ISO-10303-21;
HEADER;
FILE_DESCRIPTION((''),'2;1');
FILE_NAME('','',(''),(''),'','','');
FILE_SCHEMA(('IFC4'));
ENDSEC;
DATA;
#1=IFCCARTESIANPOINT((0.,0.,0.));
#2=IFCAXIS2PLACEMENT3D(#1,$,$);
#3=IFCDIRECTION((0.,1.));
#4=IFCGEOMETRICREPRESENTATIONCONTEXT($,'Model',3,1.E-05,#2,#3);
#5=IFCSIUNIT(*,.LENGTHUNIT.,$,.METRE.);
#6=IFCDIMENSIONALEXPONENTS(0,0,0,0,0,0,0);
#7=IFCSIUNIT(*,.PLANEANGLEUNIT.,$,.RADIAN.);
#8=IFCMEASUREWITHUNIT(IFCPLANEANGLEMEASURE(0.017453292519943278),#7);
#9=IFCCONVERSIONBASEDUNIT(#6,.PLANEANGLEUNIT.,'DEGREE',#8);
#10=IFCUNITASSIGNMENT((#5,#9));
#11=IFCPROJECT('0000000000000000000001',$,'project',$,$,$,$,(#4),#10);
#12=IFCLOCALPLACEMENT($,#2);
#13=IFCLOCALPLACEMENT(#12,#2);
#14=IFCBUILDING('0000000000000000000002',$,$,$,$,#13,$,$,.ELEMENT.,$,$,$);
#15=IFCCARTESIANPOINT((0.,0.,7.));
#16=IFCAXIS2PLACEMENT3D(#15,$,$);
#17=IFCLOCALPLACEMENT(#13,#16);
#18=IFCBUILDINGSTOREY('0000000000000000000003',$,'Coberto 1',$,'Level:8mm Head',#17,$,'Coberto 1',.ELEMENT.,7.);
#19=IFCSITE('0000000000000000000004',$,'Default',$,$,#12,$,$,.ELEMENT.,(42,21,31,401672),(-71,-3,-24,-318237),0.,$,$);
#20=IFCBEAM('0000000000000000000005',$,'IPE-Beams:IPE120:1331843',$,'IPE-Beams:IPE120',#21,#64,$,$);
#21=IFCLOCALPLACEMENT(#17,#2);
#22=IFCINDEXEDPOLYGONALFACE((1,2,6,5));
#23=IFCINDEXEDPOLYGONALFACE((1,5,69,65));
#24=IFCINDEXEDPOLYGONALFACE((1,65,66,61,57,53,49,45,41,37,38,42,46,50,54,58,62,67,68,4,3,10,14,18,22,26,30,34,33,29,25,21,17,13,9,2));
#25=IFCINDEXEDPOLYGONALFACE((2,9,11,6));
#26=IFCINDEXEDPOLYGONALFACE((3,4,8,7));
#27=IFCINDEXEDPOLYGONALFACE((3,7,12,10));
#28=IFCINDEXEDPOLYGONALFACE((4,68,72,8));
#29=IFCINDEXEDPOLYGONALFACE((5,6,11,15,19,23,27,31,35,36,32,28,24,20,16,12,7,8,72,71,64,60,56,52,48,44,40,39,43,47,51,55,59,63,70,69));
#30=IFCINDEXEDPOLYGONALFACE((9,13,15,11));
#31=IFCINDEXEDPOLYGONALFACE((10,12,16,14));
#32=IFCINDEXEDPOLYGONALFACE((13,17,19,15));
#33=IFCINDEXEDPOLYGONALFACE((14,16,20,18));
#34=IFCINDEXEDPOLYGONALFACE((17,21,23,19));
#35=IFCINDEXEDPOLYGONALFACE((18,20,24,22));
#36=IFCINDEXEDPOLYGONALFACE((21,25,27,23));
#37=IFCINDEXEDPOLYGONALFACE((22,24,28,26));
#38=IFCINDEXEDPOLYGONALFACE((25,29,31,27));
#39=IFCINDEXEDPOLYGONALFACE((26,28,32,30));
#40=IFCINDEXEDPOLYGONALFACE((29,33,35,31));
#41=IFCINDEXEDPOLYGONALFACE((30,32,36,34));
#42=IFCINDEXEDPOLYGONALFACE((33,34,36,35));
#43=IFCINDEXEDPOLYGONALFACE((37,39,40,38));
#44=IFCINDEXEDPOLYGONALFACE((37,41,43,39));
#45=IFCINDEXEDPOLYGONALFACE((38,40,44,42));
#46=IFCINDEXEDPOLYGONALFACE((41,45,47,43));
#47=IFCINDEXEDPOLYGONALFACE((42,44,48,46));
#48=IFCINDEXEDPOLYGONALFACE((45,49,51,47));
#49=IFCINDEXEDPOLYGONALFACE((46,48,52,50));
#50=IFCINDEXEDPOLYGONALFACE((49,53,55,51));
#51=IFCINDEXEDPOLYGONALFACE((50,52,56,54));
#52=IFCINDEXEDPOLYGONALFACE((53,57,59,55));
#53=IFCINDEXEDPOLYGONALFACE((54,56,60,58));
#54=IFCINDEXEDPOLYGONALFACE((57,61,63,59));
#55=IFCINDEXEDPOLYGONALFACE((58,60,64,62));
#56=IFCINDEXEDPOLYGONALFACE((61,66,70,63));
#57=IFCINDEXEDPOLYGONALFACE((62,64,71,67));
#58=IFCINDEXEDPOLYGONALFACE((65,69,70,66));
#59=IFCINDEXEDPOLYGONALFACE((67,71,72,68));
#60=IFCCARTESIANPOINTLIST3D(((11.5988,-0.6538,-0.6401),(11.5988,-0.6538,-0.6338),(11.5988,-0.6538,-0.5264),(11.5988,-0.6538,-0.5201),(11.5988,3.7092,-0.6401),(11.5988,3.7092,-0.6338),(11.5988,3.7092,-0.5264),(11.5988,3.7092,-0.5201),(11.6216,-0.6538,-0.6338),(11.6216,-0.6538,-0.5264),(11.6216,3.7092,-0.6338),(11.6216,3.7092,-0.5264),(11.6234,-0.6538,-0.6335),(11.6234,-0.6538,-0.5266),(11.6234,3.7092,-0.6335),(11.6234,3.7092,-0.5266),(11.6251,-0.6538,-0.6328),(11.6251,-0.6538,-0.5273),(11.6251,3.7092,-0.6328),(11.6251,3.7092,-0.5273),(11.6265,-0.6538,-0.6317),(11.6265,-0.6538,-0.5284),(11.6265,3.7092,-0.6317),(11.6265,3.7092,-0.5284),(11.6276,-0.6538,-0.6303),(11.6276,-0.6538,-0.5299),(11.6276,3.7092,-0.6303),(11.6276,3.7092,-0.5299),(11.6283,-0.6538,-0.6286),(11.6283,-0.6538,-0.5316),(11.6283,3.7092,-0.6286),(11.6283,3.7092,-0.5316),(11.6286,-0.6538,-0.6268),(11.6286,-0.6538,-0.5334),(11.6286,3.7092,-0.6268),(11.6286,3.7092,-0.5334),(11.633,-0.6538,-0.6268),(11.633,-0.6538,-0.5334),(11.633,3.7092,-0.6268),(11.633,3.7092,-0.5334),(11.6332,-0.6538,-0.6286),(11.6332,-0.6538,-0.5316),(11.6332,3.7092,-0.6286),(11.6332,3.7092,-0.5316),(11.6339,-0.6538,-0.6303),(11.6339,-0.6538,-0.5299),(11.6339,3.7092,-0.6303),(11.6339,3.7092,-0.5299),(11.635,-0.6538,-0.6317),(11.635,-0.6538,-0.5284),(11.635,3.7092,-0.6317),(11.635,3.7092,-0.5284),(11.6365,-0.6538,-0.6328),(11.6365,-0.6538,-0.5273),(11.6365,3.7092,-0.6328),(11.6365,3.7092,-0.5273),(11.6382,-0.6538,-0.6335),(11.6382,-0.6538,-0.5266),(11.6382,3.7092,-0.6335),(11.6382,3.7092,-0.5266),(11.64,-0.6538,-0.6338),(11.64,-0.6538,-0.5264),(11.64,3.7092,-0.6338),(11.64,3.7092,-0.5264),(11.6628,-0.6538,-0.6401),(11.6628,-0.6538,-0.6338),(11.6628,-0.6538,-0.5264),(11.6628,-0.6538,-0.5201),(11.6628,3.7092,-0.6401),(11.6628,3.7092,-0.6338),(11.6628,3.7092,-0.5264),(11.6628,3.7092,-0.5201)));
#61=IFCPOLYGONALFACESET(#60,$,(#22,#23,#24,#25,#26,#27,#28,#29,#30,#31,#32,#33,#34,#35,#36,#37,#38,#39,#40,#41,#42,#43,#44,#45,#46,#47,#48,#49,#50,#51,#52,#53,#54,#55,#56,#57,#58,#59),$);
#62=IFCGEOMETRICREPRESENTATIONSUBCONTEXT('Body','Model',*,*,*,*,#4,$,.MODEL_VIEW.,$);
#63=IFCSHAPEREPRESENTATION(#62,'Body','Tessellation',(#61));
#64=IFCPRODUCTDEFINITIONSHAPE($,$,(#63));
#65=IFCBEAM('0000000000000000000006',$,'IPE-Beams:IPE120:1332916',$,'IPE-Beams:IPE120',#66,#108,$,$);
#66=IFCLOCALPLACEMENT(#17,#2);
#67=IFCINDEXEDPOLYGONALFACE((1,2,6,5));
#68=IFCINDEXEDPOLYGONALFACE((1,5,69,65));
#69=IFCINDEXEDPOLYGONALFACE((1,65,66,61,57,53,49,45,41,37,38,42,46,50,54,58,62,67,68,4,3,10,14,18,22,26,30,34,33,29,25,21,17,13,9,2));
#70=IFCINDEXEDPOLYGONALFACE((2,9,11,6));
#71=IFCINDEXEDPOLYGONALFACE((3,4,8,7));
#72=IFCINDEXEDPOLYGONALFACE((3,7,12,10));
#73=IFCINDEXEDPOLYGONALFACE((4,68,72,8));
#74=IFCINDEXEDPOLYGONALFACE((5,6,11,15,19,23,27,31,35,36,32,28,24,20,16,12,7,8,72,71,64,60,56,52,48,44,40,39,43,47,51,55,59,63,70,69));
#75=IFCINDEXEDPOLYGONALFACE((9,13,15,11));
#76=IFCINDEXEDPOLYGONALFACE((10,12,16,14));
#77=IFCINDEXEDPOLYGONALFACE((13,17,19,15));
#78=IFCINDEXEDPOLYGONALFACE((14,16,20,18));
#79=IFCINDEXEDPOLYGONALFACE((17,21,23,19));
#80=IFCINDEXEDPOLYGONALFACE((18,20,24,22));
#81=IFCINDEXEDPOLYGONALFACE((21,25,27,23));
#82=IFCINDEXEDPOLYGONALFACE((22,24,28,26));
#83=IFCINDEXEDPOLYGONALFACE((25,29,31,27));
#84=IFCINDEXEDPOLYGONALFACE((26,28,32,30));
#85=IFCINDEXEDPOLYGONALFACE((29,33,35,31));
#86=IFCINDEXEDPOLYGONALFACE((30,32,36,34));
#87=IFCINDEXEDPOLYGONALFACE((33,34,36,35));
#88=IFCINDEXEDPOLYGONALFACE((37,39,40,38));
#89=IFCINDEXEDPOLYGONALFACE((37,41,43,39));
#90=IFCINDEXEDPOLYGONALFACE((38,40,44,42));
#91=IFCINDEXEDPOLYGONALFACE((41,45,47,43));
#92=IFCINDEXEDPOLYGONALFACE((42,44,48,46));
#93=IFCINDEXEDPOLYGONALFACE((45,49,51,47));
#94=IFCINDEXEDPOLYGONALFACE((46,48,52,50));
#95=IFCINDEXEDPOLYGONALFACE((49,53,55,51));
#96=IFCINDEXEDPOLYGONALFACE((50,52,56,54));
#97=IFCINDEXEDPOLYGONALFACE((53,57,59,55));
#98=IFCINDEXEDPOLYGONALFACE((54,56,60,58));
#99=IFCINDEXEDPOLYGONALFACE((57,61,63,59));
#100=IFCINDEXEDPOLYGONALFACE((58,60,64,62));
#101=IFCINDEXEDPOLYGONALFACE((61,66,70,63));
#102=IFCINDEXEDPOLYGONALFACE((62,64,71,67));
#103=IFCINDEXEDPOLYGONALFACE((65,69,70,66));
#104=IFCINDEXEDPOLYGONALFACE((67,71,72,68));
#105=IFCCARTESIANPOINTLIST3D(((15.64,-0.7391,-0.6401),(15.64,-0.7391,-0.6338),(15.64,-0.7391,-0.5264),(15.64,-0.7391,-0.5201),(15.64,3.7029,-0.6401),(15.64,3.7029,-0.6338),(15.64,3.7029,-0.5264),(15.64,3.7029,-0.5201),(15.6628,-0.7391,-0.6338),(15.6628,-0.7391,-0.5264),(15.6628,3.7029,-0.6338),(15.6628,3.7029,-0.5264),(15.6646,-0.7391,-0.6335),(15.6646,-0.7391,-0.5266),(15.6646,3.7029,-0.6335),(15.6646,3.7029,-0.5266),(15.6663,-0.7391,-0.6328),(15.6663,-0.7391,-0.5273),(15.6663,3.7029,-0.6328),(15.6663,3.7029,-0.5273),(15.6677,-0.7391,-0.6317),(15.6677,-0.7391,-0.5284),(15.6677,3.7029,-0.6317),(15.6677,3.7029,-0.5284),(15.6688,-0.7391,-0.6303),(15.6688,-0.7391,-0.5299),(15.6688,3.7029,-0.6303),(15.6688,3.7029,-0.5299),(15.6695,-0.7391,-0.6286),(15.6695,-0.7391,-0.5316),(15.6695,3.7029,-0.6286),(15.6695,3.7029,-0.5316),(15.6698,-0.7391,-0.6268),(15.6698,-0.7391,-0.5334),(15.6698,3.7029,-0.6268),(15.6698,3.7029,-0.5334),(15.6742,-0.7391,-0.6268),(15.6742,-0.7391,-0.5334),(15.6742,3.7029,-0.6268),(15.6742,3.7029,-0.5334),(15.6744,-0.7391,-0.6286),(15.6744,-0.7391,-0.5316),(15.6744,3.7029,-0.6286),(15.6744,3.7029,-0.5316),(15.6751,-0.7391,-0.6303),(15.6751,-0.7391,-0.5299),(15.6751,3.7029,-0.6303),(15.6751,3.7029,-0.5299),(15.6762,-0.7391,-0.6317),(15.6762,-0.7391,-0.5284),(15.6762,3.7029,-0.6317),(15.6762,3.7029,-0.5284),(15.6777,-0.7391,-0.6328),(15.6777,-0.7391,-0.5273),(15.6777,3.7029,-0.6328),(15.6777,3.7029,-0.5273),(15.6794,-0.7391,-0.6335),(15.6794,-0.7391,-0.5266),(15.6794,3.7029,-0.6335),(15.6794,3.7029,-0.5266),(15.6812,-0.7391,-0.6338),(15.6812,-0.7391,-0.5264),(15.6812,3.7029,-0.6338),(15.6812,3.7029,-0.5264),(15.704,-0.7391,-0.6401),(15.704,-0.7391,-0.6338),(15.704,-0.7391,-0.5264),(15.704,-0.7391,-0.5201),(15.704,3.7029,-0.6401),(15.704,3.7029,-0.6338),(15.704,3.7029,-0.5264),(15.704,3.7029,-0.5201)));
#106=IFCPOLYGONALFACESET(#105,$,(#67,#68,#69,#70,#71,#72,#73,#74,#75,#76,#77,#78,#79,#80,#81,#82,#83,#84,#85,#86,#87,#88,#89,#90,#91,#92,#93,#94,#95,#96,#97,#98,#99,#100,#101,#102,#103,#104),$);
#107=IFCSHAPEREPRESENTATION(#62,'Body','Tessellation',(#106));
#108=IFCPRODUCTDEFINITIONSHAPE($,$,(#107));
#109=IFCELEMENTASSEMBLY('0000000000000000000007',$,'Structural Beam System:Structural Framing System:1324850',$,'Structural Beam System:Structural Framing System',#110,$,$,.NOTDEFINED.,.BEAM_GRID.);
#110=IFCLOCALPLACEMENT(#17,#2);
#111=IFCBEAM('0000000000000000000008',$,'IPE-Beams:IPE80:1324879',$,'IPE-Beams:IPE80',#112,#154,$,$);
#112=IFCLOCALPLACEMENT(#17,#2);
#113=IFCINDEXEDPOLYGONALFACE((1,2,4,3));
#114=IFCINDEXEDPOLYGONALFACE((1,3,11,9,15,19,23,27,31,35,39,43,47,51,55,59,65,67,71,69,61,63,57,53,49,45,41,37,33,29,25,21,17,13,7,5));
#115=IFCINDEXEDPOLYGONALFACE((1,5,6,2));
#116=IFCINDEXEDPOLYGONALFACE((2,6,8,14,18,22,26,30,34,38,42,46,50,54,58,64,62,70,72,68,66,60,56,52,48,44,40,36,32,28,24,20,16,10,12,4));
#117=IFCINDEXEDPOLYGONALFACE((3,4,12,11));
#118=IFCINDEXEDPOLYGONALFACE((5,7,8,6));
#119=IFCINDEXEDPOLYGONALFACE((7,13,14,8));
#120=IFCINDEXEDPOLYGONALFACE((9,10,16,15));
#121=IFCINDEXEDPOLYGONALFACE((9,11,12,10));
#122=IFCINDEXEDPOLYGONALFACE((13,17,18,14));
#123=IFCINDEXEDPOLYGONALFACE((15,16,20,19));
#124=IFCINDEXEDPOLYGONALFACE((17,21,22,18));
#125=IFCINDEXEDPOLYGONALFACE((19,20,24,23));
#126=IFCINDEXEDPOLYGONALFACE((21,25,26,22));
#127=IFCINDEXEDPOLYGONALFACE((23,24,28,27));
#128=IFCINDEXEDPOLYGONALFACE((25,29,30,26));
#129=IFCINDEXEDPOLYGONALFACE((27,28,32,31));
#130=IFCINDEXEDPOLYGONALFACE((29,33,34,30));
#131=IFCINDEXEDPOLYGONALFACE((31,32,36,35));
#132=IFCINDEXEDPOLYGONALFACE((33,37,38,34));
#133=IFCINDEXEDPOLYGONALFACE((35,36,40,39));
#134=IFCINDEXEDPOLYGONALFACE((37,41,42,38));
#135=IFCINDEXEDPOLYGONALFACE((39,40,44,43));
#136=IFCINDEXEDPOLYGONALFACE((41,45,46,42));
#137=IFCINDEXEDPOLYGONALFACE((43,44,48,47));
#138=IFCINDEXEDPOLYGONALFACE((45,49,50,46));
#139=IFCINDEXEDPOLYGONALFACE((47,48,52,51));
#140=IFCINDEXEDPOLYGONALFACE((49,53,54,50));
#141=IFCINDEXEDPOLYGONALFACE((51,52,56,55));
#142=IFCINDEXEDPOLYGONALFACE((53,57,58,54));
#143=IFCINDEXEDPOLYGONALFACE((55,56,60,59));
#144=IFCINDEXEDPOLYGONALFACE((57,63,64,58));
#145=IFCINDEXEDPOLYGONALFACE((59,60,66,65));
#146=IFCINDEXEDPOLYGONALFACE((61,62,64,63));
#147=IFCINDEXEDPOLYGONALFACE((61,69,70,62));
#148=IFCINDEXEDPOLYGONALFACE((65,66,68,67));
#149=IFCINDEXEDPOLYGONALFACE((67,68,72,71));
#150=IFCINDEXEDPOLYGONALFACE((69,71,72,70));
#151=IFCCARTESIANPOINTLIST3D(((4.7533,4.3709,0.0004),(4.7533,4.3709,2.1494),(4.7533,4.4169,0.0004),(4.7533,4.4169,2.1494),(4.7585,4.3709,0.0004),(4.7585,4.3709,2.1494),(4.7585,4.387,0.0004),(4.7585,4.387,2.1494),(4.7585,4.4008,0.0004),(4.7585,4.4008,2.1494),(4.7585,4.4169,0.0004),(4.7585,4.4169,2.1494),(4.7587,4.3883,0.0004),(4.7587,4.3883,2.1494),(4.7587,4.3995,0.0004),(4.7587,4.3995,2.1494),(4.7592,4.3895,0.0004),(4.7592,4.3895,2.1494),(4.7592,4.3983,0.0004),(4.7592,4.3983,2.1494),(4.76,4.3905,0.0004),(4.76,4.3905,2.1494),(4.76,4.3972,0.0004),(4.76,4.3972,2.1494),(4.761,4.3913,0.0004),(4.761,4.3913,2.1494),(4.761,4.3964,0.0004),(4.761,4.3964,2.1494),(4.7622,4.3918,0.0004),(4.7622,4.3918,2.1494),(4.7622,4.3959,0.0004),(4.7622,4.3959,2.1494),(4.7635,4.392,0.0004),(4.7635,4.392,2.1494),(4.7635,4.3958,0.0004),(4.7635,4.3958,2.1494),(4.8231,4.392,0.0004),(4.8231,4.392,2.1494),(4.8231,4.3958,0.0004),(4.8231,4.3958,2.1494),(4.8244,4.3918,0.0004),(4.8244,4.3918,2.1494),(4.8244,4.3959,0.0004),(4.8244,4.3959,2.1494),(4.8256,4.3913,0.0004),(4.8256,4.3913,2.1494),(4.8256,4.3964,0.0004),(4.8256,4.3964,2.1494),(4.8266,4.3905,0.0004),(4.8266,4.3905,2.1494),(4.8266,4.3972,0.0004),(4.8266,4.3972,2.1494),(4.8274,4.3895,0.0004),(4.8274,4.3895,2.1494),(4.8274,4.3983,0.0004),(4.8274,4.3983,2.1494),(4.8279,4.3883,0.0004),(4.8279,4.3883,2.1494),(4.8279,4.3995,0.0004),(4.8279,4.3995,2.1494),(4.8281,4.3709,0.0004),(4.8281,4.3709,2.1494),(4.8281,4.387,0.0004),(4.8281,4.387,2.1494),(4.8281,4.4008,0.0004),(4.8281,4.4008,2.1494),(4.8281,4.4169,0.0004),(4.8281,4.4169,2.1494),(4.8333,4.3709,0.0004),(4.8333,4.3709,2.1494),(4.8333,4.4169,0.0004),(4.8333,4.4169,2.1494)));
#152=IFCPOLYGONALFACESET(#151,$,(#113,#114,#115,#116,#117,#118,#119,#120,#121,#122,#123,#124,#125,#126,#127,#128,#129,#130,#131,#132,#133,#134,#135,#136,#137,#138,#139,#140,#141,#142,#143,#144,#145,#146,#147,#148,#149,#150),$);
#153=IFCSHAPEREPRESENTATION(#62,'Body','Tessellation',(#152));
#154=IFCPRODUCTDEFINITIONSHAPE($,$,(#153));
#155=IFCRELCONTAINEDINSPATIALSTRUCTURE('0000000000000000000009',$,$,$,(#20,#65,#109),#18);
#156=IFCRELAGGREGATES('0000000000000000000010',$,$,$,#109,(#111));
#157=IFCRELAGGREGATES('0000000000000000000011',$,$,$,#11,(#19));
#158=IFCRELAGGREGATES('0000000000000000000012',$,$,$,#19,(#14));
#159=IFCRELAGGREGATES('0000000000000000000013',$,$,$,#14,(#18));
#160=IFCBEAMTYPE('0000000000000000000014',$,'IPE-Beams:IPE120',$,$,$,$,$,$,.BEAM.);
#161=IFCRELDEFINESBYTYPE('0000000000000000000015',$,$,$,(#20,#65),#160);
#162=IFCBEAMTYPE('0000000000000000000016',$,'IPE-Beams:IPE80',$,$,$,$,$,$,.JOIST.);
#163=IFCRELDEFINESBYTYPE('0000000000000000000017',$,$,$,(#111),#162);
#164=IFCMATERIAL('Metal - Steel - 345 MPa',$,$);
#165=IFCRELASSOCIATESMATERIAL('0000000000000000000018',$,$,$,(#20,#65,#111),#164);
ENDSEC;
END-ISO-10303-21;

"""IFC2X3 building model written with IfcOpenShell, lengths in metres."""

from ifc_helpers import new_model, entity, si_unit, converted_unit, direction, frame, frame_2d, origin, place, context, subcontext, project, spatial, polyline, circle_curve, parameter, trimmed, segment, composite_curve, i_section, outline, extrude, material, type_object, element, aggregate, save


model = new_model("IFC2X3")

# Units and contexts
model_context = context("Model", 3, precision=1e-05, world=origin(), true_north=direction((0.0, 1.0)))
body_context = subcontext(model_context, "Body", "Model", "MODEL_VIEW")
ifc_project = project(units=[si_unit("LENGTHUNIT", "METRE"), converted_unit("PLANEANGLEUNIT", "DEGREE", entity("IfcPlaneAngleMeasure", 0.017453292519943278), si_unit("PLANEANGLEUNIT", "RADIAN"), dimensions=[0, 0, 0, 0, 0, 0, 0])], contexts=[model_context])

# Site, building, storey
site_placement = place(None, origin())
site = spatial("IfcSite", under=ifc_project, at=site_placement, Name="Default", CompositionType="ELEMENT", RefLatitude=(42, 21, 31, 401672), RefLongitude=(-71, -3, -24, -318237), RefElevation=0.0)
building_placement = place(site_placement, origin())
building = spatial("IfcBuilding", under=site, at=building_placement, CompositionType="ELEMENT")
storey_placement = place(building_placement, frame((0.0, 0.0, 7.0)))
storey = spatial("IfcBuildingStorey", under=building, at=storey_placement, Name="Coberto 1", ObjectType="Level:8mm Head", LongName="Coberto 1", CompositionType="ELEMENT", Elevation=7.0)

# Shared definitions
ifc_material_1 = material(Name="Metal - Steel - 345 MPa")

# Beams
beam_type_1 = type_object("IfcBeamType", Name="IPE-Beams:IPE120", PredefinedType="BEAM")
beam_1_placement = place(storey_placement, frame((11.6308, -0.705, -0.5801), z_axis=(0.0, 0.0, 1.0), x_axis=(0.0, 1.0, 0.0)))
element("IfcBeam", 1, at=beam_1_placement, inside=storey, type_object=beam_type_1, material=ifc_material_1, Name="IPE-Beams:IPE120:1331843", ObjectType="IPE-Beams:IPE120", context=body_context, shape_type="SweptSolid", body=[
    extrude(i_section(OverallWidth=0.064, OverallDepth=0.12, WebThickness=0.0044, FlangeThickness=0.0063, FilletRadius=0.007, at=frame_2d((0.0, 0.0), x_axis=(0.0, 1.0))), frame((0.0511, 0.0, 0.0), z_axis=(1.0, 0.0, 0.0), x_axis=(0.0, 0.0, -1.0)), (0.0, 0.0, 1.0), 4.363),
])
beam_2_placement = place(storey_placement, frame((15.672, -0.6995, -0.5801), z_axis=(0.0, 0.0, 1.0), x_axis=(0.0, 1.0, 0.0)))
element("IfcBeam", 2, at=beam_2_placement, inside=storey, type_object=beam_type_1, material=ifc_material_1, Name="IPE-Beams:IPE120:1332916", ObjectType="IPE-Beams:IPE120", context=body_context, shape_type="SweptSolid", body=[
    extrude(i_section(OverallWidth=0.064, OverallDepth=0.12, WebThickness=0.0044, FlangeThickness=0.0063, FilletRadius=0.007, at=frame_2d((0.0, 0.0), x_axis=(0.0, 1.0))), frame((-0.0396, 0.0, 0.0), z_axis=(1.0, 0.0, 0.0), x_axis=(0.0, 0.0, -1.0)), (0.0, 0.0, 1.0), 4.442),
])

# Element assembly, beam
assembly_1_placement = place(storey_placement, origin())
assembly_1 = element("IfcElementAssembly", 3, at=assembly_1_placement, inside=storey, Name="Structural Beam System:Structural Framing System:1324850", ObjectType="Structural Beam System:Structural Framing System", AssemblyPlace="NOTDEFINED", PredefinedType="BEAM_GRID")
beam_type_2 = type_object("IfcBeamType", Name="IPE-Beams:IPE80", PredefinedType="JOIST")
beam_3_placement = place(assembly_1_placement, frame((4.7533, 4.3939, 2.1498), z_axis=(1.0, 0.0, 0.0), x_axis=(0.0, 0.0, -1.0)))
beam_3 = element("IfcBeam", 4, at=beam_3_placement, type_object=beam_type_2, material=ifc_material_1, Name="IPE-Beams:IPE80:1324879", ObjectType="IPE-Beams:IPE80", context=body_context, shape_type="SweptSolid", body=[
    extrude(outline(composite_curve([segment(polyline([(0.0348, -0.023), (0.04, -0.023)]), True, "CONTINUOUS"), segment(polyline([(0.04, -0.023), (0.04, 0.023)]), True, "CONTINUOUS"), segment(polyline([(0.04, 0.023), (0.0348, 0.023)]), True, "CONTINUOUS"), segment(polyline([(0.0348, 0.023), (0.0348, 0.0069)]), True, "CONTINUOUS"), segment(trimmed(circle_curve(frame_2d((0.0298, 0.0069), x_axis=(1.0, 0.0)), 0.005), [parameter(270.0)], [parameter(0.0)], True, "PARAMETER"), False, "CONTINUOUS"), segment(polyline([(0.0298, 0.0019), (-0.0298, 0.0019)]), True, "CONTINUOUS"), segment(trimmed(circle_curve(frame_2d((-0.0298, 0.0069), x_axis=(0.0, -1.0)), 0.005), [parameter(270.0)], [parameter(0.0)], True, "PARAMETER"), False, "CONTINUOUS"), segment(polyline([(-0.0348, 0.0069), (-0.0348, 0.023)]), True, "CONTINUOUS"), segment(polyline([(-0.0348, 0.023), (-0.04, 0.023)]), True, "CONTINUOUS"), segment(polyline([(-0.04, 0.023), (-0.04, -0.023)]), True, "CONTINUOUS"), segment(polyline([(-0.04, -0.023), (-0.0348, -0.023)]), True, "CONTINUOUS"), segment(polyline([(-0.0348, -0.023), (-0.0348, -0.0069)]), True, "CONTINUOUS"), segment(trimmed(circle_curve(frame_2d((-0.0298, -0.0069), x_axis=(-1.0, 0.0)), 0.005), [parameter(270.0)], [parameter(0.0)], True, "PARAMETER"), False, "CONTINUOUS"), segment(polyline([(-0.0298, -0.0019), (0.0298, -0.0019)]), True, "CONTINUOUS"), segment(trimmed(circle_curve(frame_2d((0.0298, -0.0069), x_axis=(0.0, 1.0)), 0.005), [parameter(270.0)], [parameter(0.0)], True, "PARAMETER"), False, "CONTINUOUS"), segment(polyline([(0.0348, -0.0069), (0.0348, -0.023)]), True, "CONTINUOUS")], self_intersect=False)), frame((0.0004, 0.0, 0.04), z_axis=(1.0, 0.0, 0.0), x_axis=(0.0, 0.0, -1.0)), (0.0, 0.0, 1.0), 2.149),
])
aggregate(assembly_1, [beam_3])

save(model, "model.ifc")
